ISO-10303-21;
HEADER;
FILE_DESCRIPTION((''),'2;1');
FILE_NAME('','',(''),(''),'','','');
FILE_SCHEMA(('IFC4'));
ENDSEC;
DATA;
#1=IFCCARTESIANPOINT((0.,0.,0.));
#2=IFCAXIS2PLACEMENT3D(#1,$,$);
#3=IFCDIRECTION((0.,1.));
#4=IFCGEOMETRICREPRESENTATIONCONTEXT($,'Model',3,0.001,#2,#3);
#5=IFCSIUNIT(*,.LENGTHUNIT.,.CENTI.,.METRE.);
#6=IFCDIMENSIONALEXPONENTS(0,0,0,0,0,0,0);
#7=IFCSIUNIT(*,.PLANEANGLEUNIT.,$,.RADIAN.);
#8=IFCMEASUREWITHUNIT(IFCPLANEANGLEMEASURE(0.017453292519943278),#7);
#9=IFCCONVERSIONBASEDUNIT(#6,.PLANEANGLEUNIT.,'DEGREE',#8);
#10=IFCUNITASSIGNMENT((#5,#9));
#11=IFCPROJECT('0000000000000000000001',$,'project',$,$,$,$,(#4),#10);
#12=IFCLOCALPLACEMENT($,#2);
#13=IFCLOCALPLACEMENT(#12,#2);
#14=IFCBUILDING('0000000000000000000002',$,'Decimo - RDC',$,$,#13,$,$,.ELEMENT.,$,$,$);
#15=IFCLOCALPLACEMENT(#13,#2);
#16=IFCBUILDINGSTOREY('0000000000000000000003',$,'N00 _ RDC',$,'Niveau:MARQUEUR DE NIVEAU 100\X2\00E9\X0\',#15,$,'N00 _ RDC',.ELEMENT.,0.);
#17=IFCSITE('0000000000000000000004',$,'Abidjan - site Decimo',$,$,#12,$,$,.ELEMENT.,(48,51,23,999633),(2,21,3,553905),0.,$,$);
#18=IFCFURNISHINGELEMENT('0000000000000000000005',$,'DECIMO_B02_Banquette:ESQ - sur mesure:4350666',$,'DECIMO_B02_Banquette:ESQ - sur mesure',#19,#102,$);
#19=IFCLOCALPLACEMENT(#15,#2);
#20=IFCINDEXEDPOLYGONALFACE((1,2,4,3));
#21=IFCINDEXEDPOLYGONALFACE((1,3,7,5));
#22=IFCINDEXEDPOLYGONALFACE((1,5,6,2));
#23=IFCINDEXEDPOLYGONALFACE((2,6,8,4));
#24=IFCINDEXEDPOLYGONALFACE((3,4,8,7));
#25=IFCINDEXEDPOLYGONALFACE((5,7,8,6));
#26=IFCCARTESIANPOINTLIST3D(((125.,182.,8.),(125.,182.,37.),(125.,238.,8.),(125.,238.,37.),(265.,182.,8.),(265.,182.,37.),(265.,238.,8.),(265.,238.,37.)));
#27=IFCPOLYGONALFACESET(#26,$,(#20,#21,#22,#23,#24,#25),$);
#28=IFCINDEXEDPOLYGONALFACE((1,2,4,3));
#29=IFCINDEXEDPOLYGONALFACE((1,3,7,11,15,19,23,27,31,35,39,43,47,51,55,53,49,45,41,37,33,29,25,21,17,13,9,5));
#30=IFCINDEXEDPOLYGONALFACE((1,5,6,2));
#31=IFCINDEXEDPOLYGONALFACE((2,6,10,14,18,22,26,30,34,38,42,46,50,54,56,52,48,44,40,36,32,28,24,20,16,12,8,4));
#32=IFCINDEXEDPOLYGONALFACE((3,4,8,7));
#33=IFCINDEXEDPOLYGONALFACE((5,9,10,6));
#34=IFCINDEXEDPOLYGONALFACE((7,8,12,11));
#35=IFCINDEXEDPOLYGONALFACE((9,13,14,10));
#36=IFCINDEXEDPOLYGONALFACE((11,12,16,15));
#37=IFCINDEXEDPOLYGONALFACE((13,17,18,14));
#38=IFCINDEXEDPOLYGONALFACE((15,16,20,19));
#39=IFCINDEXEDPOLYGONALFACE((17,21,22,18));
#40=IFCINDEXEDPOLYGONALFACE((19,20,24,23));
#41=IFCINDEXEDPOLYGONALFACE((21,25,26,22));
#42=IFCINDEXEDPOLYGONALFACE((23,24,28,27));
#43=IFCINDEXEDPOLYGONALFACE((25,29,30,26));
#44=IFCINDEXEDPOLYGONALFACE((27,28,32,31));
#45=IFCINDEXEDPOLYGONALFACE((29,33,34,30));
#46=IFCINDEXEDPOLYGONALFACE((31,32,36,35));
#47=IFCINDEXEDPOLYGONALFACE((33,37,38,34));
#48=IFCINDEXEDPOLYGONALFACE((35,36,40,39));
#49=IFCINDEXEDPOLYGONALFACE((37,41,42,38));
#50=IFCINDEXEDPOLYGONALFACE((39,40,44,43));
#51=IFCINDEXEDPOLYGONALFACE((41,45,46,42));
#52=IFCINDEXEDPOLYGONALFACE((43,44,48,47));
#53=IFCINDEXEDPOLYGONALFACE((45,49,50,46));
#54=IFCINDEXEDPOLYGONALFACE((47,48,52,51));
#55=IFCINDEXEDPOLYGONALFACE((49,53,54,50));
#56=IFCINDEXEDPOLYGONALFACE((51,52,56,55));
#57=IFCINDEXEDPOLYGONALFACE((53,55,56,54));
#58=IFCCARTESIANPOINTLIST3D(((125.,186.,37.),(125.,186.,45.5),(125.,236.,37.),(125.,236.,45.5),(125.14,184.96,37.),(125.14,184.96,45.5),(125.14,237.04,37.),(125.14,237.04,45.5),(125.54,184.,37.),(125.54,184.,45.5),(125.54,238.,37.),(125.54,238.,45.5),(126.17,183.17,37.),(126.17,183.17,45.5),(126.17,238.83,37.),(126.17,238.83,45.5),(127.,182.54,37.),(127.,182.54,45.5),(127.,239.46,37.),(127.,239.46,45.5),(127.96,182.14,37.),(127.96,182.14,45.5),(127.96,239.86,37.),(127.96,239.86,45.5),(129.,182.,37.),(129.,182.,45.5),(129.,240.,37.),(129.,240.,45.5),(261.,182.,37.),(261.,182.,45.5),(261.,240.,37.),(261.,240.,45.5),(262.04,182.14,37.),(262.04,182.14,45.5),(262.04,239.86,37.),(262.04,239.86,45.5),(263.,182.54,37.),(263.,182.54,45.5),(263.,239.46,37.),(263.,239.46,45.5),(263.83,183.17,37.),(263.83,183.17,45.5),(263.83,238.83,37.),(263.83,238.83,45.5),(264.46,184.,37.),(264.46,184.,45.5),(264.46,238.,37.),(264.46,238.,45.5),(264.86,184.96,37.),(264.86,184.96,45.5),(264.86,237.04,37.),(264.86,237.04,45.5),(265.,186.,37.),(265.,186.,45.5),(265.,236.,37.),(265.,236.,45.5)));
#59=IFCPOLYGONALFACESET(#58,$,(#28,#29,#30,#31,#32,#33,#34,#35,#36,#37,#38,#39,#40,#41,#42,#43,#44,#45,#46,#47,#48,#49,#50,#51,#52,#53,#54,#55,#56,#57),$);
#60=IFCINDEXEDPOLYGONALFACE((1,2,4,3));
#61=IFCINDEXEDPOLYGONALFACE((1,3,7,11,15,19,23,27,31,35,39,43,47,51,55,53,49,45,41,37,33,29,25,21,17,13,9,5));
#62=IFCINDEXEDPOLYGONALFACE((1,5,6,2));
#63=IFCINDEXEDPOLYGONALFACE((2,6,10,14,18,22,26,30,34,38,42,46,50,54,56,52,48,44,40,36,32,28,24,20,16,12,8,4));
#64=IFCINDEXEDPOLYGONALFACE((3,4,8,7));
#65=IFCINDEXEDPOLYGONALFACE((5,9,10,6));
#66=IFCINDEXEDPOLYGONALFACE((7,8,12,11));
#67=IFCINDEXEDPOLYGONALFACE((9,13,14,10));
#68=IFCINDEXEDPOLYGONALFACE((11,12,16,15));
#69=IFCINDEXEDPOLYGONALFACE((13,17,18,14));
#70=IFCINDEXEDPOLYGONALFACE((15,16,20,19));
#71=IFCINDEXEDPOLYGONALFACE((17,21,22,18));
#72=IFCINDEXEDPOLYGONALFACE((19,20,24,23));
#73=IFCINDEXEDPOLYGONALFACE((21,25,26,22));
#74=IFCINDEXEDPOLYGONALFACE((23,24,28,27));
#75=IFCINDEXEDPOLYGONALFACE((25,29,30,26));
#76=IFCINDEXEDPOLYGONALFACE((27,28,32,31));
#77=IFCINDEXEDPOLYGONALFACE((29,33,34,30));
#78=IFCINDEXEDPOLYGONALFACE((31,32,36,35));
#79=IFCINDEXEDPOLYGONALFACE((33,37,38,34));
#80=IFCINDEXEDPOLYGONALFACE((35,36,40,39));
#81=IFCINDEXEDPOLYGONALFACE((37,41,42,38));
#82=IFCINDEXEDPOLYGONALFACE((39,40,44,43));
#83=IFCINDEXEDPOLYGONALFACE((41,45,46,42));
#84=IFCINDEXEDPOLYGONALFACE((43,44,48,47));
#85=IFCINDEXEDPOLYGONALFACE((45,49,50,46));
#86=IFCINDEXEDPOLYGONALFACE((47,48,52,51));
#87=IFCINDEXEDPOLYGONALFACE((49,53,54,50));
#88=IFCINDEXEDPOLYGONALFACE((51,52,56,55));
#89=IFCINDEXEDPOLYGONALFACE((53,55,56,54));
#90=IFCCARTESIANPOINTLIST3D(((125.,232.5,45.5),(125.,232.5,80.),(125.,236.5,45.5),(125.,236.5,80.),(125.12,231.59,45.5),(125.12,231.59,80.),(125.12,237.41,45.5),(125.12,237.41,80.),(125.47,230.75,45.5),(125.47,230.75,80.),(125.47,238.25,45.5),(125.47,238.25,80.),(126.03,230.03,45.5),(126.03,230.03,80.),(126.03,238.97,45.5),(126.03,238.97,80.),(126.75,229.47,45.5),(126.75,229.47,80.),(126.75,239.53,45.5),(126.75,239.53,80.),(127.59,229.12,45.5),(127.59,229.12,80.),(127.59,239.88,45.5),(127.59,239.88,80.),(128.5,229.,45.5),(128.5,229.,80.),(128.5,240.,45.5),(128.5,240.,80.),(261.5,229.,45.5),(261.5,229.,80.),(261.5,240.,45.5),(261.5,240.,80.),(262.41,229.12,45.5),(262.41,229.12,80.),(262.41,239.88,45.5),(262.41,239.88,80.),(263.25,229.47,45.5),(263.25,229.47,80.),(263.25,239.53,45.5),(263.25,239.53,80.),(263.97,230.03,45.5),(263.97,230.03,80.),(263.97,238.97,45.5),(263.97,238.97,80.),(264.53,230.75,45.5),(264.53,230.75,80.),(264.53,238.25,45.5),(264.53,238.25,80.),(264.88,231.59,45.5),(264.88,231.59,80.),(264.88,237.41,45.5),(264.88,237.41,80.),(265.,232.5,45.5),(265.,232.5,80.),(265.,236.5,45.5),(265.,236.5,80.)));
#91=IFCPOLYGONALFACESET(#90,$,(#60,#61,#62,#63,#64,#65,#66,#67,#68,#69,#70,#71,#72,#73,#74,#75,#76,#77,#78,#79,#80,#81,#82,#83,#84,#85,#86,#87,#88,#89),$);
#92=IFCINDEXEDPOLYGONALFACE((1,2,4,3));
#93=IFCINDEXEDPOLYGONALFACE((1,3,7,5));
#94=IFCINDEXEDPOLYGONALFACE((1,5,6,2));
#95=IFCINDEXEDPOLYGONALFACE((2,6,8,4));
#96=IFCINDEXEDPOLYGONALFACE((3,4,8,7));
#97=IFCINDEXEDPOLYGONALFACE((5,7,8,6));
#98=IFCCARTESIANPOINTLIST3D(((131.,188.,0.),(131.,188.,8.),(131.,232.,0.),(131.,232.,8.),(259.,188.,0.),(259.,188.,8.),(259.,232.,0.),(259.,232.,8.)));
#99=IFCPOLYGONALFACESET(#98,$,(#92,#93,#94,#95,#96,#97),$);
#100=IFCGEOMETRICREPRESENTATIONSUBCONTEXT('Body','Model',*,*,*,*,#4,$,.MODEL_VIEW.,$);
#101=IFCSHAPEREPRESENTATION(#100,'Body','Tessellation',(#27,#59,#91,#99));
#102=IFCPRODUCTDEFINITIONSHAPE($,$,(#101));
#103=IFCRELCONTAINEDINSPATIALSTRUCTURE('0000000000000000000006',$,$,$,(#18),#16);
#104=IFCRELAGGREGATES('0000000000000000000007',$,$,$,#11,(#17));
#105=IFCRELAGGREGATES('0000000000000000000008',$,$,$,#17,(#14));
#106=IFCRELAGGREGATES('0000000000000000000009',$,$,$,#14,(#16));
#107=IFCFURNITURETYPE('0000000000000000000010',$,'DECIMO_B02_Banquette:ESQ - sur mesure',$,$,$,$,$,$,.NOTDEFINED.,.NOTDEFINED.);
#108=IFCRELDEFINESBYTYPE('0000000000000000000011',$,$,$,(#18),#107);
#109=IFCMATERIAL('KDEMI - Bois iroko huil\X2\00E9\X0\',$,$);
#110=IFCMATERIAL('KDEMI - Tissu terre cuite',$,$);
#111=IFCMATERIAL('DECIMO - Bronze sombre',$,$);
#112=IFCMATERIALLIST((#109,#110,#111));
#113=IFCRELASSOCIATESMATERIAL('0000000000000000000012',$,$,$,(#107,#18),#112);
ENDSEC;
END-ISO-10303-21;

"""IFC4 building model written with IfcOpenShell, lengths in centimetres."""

from ifc_helpers import new_model, entity, si_unit, converted_unit, direction, frame, frame_2d, origin, origin_2d_with_axis, place, context, subcontext, project, spatial, polyline, circle_curve, parameter, trimmed, segment, composite_curve, rectangle, outline, extrude, source, transform, mapped, material, material_list, type_object, type_shapes, element, save


model = new_model("IFC4")

# Units and contexts
model_context = context("Model", 3, precision=0.001, world=origin(), true_north=direction((0.0, 1.0)))
body_context = subcontext(model_context, "Body", "Model", "MODEL_VIEW")
ifc_project = project(units=[si_unit("LENGTHUNIT", "METRE", prefix="CENTI"), converted_unit("PLANEANGLEUNIT", "DEGREE", entity("IfcPlaneAngleMeasure", 0.017453292519943278), si_unit("PLANEANGLEUNIT", "RADIAN"), dimensions=[0, 0, 0, 0, 0, 0, 0])], contexts=[model_context])

# Site, building, storey
site_placement = place(None, origin())
site = spatial("IfcSite", under=ifc_project, at=site_placement, Name="Abidjan - site Decimo", CompositionType="ELEMENT", RefLatitude=(48, 51, 23, 999633), RefLongitude=(2, 21, 3, 553905), RefElevation=0.0)
building_placement = place(site_placement, origin())
building = spatial("IfcBuilding", under=site, at=building_placement, Name="Decimo - RDC", CompositionType="ELEMENT")
storey_placement = place(building_placement, origin())
storey = spatial("IfcBuildingStorey", under=building, at=storey_placement, Name="N00 _ RDC", ObjectType="Niveau:MARQUEUR DE NIVEAU 100é", LongName="N00 _ RDC", CompositionType="ELEMENT", Elevation=0.0)

# Furnishing element
ifc_material_1 = material(Name="KDEMI - Bois iroko huilé")
ifc_material_2 = material(Name="DECIMO - Bronze sombre")
ifc_material_3 = material(Name="KDEMI - Tissu terre cuite")
ifc_material_list_1 = material_list([ifc_material_1, ifc_material_3, ifc_material_2])
furniture_type_1 = type_object("IfcFurnitureType", Name="DECIMO_B02_Banquette:ESQ - sur mesure", AssemblyPlace="NOTDEFINED", material=ifc_material_list_1)
shared_shape_1 = source(origin(), body_context, "Body", "SweptSolid", [
    extrude(rectangle(XDim=140.0, YDim=56.0, at=origin_2d_with_axis()), frame((70.0, 28.0, 8.0)), (0.0, 0.0, 1.0), 29.0),
    extrude(outline(composite_curve([segment(polyline([(-66.0, -29.0), (66.0, -29.0)]), True, "CONTINUOUS"), segment(trimmed(circle_curve(frame_2d((66.0, -25.0), x_axis=(1.0, 0.0)), 4.0), [parameter(270.0)], [parameter(0.0)], True, "PARAMETER"), True, "CONTINUOUS"), segment(polyline([(70.0, -25.0), (70.0, 25.0)]), True, "CONTINUOUS"), segment(trimmed(circle_curve(frame_2d((66.0, 25.0), x_axis=(1.0, 0.0)), 4.0), [parameter(0.0)], [parameter(90.0)], True, "PARAMETER"), True, "CONTINUOUS"), segment(polyline([(66.0, 29.0), (-66.0, 29.0)]), True, "CONTINUOUS"), segment(trimmed(circle_curve(frame_2d((-66.0, 25.0), x_axis=(1.0, 0.0)), 4.0), [parameter(90.0)], [parameter(180.0)], True, "PARAMETER"), True, "CONTINUOUS"), segment(polyline([(-70.0, 25.0), (-70.0, -25.0)]), True, "CONTINUOUS"), segment(trimmed(circle_curve(frame_2d((-66.0, -25.0), x_axis=(1.0, 0.0)), 4.0), [parameter(180.0)], [parameter(270.0)], True, "PARAMETER"), True, "CONTINUOUS")], self_intersect=False)), frame((70.0, 29.0, 37.0)), (0.0, 0.0, 1.0), 8.5),
    extrude(outline(composite_curve([segment(polyline([(-66.5, -5.5), (66.5, -5.5)]), True, "CONTINUOUS"), segment(trimmed(circle_curve(frame_2d((66.5, -2.0), x_axis=(1.0, 0.0)), 3.5), [parameter(270.0)], [parameter(0.0)], True, "PARAMETER"), True, "CONTINUOUS"), segment(polyline([(70.0, -2.0), (70.0, 2.0)]), True, "CONTINUOUS"), segment(trimmed(circle_curve(frame_2d((66.5, 2.0), x_axis=(1.0, 0.0)), 3.5), [parameter(0.0)], [parameter(90.0)], True, "PARAMETER"), True, "CONTINUOUS"), segment(polyline([(66.5, 5.5), (-66.5, 5.5)]), True, "CONTINUOUS"), segment(trimmed(circle_curve(frame_2d((-66.5, 2.0), x_axis=(1.0, 0.0)), 3.5), [parameter(90.0)], [parameter(180.0)], True, "PARAMETER"), True, "CONTINUOUS"), segment(polyline([(-70.0, 2.0), (-70.0, -2.0)]), True, "CONTINUOUS"), segment(trimmed(circle_curve(frame_2d((-66.5, -2.0), x_axis=(1.0, 0.0)), 3.5), [parameter(180.0)], [parameter(270.0)], True, "PARAMETER"), True, "CONTINUOUS")], self_intersect=False)), frame((70.0, 52.5, 45.5)), (0.0, 0.0, 1.0), 34.5),
    extrude(rectangle(XDim=128.0, YDim=44.0, at=frame_2d((0.0, 0.0), x_axis=(1.0, 0.0))), frame((70.0, 28.0, 0.0)), (0.0, 0.0, 1.0), 8.0),
])
type_shapes(furniture_type_1, [shared_shape_1])
furnishing_1_placement = place(storey_placement, frame((125.0, 182.0, 0.0)))
element("IfcFurnishingElement", 1, at=furnishing_1_placement, inside=storey, type_object=furniture_type_1, material=ifc_material_list_1, Name="DECIMO_B02_Banquette:ESQ - sur mesure:4350666", ObjectType="DECIMO_B02_Banquette:ESQ - sur mesure", context=body_context, shape_type="MappedRepresentation", body=[
    mapped(shared_shape_1, transform((0.0, 0.0, 0.0), scale=1.0)),
])

save(model, "model.ifc")
